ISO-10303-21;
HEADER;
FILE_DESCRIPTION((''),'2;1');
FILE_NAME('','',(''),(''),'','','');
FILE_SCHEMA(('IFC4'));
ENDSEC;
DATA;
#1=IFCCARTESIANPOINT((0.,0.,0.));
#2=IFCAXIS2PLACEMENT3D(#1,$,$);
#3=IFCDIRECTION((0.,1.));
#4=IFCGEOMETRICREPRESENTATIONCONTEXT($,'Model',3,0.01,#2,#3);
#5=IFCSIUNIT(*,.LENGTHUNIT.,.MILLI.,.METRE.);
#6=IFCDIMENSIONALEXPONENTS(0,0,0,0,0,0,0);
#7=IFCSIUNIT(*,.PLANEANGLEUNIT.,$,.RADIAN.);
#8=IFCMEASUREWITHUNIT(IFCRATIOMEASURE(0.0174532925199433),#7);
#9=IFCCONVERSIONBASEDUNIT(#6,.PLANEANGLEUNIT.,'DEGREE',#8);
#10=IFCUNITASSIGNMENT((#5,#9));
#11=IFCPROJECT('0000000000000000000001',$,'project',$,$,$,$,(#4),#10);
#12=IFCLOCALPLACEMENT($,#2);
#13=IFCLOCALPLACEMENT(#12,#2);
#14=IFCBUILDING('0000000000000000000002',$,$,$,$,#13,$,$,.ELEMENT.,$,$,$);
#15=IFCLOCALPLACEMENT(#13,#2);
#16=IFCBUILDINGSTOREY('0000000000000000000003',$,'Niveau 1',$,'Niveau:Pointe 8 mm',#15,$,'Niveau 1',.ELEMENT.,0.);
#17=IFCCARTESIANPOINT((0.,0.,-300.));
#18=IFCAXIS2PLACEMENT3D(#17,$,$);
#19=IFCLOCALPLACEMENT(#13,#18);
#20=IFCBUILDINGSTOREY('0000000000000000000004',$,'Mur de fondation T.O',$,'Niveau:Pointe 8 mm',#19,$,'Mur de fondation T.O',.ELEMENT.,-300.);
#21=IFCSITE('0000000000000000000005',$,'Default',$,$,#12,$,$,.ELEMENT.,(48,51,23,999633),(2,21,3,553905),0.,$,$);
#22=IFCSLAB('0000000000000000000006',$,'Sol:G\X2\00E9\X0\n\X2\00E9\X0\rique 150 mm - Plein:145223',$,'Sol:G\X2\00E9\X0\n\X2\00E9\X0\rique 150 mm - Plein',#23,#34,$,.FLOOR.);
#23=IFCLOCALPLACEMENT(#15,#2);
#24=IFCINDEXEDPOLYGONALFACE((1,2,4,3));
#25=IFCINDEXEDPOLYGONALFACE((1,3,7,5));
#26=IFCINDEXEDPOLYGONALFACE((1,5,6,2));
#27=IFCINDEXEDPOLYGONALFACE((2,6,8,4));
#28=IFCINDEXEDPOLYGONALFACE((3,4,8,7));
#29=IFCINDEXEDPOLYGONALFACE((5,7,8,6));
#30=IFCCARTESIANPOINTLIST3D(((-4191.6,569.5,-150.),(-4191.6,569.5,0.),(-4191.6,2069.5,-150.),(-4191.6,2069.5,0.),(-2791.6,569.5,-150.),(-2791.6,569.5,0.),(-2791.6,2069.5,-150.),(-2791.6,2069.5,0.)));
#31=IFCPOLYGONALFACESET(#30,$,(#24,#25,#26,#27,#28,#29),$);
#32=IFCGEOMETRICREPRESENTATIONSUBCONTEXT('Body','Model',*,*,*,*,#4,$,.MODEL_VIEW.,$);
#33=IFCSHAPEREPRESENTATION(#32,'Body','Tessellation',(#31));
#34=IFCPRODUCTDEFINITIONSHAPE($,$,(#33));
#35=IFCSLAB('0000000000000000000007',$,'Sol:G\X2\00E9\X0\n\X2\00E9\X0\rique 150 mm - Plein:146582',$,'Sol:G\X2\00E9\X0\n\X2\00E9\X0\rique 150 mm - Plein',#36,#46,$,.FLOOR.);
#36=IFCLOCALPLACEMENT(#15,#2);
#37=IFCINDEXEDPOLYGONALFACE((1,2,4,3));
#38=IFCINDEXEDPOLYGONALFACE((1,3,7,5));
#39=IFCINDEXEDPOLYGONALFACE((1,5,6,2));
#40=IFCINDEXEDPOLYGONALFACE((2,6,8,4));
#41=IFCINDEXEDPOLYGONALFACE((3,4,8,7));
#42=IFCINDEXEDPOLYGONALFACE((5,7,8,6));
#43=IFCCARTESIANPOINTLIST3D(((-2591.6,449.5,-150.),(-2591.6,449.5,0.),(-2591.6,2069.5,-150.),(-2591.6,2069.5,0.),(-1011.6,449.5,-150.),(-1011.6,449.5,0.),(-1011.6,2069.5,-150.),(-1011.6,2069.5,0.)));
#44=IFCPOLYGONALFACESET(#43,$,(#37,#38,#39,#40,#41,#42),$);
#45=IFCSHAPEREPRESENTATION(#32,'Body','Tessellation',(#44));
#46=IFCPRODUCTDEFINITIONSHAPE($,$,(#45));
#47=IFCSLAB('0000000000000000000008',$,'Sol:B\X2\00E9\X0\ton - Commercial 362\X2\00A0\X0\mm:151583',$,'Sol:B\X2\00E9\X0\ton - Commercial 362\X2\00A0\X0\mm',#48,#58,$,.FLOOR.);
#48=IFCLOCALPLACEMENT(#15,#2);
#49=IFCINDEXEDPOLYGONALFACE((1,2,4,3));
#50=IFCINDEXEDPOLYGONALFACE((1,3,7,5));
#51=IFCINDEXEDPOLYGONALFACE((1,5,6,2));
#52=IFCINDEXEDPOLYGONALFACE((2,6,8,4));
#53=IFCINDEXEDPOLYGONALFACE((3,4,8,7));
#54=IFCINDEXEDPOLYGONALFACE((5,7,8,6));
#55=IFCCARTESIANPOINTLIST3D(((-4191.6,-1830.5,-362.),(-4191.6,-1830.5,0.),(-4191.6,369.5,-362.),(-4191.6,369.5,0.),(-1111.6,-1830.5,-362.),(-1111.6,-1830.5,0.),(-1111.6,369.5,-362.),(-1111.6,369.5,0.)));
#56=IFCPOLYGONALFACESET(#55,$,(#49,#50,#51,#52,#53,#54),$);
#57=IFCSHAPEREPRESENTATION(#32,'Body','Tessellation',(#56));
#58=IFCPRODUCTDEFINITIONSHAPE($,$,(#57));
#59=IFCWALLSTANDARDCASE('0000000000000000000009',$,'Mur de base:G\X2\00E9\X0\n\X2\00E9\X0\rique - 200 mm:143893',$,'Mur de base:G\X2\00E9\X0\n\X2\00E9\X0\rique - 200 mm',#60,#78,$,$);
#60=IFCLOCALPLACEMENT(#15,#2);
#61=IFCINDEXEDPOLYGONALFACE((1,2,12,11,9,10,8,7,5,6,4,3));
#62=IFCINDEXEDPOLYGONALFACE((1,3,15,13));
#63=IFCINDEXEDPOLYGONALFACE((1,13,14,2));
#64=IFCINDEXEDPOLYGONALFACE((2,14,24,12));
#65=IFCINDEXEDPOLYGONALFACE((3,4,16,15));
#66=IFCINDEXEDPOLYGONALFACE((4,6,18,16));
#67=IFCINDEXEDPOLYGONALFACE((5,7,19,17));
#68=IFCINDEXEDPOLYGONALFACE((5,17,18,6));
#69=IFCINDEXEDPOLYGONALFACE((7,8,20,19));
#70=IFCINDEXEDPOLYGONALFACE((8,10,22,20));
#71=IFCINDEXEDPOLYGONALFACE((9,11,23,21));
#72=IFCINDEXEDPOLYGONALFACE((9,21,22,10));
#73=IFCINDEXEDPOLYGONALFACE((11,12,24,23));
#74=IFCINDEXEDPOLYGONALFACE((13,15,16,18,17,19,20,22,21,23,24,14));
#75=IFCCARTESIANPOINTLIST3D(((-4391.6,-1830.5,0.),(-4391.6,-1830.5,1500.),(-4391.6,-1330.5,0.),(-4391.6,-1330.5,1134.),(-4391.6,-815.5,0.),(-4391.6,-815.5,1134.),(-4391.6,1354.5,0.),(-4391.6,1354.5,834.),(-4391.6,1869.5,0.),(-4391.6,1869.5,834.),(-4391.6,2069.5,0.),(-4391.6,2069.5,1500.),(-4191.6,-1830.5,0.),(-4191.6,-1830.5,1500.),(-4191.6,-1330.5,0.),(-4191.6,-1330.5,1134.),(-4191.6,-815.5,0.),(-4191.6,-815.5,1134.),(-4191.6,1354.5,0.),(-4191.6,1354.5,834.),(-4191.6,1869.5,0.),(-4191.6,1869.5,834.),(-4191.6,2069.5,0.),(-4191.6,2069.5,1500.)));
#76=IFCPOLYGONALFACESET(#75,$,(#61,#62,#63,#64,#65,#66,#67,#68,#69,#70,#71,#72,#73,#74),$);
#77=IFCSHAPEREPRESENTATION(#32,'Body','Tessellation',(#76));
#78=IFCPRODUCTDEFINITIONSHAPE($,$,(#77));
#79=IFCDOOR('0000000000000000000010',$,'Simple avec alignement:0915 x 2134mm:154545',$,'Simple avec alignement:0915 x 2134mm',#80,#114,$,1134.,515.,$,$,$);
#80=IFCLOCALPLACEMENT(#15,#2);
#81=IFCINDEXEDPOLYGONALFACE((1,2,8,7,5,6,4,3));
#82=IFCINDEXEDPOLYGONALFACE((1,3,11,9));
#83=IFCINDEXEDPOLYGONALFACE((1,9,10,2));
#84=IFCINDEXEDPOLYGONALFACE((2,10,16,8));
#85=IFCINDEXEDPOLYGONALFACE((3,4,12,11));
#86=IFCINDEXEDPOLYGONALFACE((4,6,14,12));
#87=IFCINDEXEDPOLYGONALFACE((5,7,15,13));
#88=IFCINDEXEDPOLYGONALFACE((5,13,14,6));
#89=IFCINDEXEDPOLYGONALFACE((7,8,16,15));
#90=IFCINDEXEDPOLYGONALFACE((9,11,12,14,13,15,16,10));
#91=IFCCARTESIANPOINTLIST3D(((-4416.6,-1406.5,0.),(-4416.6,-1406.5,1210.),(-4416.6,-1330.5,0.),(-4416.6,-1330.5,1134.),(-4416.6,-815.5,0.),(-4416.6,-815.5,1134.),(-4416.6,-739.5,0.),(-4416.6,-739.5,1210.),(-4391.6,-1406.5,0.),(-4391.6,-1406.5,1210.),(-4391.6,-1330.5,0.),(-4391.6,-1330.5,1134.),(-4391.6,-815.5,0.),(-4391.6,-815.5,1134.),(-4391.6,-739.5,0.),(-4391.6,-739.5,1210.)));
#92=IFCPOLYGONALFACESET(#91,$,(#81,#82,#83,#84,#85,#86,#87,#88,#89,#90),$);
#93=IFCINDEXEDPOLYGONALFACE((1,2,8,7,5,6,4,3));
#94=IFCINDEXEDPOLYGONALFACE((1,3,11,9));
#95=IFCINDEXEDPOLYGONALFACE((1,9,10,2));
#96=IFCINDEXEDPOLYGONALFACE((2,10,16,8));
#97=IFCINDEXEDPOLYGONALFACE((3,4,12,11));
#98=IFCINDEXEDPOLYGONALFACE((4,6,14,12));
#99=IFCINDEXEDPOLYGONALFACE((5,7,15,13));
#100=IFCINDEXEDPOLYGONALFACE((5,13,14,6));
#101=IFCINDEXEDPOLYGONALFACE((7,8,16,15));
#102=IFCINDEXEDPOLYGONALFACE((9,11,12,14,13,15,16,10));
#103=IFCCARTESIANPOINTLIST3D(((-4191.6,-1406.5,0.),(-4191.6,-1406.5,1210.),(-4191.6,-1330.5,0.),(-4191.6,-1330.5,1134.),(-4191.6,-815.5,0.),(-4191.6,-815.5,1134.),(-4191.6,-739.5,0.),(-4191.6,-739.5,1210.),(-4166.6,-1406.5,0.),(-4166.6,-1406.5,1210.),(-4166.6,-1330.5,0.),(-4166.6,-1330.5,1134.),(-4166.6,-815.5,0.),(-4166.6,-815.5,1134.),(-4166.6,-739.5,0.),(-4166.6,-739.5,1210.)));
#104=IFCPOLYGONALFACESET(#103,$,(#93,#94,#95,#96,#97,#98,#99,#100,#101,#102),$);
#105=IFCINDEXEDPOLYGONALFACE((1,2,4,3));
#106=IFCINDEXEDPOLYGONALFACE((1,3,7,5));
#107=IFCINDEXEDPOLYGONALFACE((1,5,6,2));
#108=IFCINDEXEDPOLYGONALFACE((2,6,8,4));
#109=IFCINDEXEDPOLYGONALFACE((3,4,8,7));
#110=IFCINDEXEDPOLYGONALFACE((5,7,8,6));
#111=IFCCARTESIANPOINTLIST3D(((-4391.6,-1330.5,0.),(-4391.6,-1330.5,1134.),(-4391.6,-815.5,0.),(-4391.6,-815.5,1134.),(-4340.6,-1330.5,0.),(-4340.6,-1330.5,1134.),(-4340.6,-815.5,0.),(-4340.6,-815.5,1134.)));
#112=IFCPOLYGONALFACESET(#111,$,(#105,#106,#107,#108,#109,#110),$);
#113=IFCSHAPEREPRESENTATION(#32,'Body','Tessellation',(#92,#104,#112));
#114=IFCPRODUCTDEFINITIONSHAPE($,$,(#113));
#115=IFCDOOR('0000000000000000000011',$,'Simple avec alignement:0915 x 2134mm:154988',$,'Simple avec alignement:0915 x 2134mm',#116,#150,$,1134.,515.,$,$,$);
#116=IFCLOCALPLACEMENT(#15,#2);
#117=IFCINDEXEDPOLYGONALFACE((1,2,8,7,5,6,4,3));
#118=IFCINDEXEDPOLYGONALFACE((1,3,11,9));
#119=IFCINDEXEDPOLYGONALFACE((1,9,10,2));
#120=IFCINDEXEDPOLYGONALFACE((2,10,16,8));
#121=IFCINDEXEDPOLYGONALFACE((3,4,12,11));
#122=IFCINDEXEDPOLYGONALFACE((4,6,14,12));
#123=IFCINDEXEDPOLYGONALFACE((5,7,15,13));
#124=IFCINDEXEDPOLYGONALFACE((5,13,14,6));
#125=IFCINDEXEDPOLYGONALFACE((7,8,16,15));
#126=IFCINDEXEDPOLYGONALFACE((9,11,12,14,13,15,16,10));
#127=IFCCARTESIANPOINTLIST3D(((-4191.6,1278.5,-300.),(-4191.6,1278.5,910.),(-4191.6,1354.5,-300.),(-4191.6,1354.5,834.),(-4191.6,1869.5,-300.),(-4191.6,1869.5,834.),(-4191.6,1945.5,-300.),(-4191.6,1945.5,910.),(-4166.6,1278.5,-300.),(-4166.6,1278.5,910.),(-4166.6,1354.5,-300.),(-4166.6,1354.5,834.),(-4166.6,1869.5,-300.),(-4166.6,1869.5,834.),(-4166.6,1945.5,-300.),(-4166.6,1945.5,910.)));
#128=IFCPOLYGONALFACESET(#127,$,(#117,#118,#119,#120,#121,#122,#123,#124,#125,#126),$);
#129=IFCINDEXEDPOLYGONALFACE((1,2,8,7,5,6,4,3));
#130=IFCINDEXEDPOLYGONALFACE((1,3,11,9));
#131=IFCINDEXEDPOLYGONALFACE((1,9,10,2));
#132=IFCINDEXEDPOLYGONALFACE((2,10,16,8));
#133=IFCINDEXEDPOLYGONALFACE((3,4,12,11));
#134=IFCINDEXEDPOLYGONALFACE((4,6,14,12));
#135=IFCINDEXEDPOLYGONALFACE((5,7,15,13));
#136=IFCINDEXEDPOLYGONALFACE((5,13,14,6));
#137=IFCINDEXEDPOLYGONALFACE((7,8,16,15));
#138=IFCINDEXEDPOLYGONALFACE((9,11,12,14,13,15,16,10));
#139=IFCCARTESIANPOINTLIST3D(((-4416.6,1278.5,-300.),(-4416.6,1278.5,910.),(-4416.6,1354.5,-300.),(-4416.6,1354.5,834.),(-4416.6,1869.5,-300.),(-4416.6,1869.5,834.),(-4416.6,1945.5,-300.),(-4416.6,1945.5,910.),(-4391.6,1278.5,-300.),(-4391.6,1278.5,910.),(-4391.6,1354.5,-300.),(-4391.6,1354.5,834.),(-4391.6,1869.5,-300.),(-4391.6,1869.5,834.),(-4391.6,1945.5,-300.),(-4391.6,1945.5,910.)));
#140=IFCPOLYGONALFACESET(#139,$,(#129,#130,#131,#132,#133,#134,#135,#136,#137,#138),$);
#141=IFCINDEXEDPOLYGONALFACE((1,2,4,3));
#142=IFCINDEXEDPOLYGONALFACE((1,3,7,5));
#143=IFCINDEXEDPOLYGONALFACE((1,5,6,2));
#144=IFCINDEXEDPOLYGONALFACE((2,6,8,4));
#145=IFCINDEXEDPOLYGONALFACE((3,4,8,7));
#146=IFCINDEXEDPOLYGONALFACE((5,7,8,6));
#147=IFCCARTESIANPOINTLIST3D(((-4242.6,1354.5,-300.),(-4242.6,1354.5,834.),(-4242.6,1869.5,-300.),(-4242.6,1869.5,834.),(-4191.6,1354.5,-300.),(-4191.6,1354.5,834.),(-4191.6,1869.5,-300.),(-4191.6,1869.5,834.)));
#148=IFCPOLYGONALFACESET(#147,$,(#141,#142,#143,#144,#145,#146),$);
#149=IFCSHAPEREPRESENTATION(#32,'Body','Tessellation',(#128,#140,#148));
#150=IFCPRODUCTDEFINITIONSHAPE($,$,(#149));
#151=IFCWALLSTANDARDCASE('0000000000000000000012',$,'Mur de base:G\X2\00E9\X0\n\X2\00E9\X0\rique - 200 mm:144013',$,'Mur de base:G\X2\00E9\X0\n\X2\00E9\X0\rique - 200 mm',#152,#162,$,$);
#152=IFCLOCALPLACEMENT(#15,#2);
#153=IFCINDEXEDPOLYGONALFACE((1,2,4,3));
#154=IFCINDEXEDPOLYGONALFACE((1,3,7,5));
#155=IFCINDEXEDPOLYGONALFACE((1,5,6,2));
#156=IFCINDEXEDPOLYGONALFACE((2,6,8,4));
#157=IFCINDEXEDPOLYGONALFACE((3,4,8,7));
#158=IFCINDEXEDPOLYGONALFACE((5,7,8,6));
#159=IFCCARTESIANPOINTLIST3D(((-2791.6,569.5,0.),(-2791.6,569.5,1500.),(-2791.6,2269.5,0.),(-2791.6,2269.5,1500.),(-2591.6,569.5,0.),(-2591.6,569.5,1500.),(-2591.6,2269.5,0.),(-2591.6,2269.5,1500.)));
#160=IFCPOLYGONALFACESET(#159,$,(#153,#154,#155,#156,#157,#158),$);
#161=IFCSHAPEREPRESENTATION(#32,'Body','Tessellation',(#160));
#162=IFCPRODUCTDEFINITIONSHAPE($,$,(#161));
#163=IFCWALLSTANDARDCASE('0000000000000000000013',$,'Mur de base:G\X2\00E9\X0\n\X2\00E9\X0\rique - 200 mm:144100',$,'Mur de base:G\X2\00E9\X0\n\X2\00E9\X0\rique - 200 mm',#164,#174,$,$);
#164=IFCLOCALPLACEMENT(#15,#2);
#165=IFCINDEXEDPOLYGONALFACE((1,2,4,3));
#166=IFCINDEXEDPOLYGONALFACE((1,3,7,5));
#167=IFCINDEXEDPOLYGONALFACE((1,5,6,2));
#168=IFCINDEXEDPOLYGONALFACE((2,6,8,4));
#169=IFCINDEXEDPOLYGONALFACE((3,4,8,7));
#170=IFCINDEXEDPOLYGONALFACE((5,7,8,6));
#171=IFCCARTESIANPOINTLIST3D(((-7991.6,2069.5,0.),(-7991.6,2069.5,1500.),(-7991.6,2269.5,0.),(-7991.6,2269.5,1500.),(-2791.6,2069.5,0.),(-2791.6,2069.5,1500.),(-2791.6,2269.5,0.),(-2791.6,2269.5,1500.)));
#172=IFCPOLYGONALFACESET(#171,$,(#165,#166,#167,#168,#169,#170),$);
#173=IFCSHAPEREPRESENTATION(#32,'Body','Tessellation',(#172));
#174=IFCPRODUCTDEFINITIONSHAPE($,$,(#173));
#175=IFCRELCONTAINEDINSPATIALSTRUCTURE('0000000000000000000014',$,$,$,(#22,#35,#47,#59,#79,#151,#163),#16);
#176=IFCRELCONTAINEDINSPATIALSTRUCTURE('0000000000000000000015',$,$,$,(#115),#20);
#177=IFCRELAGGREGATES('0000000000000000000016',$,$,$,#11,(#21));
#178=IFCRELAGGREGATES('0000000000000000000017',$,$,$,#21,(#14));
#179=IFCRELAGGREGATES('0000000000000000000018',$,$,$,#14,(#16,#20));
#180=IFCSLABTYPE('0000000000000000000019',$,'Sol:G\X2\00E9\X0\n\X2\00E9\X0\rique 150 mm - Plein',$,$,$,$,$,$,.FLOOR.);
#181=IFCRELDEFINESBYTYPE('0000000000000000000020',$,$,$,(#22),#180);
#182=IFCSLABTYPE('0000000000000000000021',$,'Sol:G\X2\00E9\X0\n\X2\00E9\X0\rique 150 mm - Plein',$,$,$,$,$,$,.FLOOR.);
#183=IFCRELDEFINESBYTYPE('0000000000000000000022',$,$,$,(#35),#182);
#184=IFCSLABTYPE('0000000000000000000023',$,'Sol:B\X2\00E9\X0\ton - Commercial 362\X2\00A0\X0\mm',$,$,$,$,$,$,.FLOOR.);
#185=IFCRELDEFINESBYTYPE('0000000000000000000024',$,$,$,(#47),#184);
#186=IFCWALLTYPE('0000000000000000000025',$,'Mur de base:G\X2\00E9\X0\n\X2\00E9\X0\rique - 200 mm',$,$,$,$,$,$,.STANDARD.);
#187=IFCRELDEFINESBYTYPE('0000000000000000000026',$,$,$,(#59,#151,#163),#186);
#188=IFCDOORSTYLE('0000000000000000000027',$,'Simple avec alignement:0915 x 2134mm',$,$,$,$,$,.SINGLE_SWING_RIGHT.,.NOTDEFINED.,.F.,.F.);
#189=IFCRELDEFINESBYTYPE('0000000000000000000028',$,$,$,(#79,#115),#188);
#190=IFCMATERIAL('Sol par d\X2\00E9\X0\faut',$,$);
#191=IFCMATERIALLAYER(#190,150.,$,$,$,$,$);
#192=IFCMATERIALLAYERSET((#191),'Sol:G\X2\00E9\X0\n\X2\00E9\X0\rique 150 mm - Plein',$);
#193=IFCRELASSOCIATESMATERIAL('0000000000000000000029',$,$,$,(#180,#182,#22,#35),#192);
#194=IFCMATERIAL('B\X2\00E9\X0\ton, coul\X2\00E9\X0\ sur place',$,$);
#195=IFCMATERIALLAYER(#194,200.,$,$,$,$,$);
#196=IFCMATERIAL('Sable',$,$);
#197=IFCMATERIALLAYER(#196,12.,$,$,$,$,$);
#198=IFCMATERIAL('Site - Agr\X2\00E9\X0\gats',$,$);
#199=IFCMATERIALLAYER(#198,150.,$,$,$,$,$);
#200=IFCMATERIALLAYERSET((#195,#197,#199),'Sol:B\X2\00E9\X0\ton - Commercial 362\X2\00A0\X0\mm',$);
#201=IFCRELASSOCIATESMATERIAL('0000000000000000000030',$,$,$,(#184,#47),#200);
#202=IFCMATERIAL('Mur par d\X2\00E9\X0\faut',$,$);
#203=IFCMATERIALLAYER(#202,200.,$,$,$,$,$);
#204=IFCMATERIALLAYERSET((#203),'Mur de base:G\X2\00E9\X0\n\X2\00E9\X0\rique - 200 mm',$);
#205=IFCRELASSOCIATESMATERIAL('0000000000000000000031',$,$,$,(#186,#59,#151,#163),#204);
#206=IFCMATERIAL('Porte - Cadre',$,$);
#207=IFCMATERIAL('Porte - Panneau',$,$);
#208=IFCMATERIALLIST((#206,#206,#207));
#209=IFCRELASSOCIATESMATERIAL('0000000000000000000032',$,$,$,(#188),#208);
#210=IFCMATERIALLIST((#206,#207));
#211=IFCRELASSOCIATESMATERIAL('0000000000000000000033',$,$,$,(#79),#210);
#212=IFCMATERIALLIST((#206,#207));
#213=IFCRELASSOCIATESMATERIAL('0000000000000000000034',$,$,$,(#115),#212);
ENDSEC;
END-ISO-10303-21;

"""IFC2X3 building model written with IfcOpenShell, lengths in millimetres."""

from ifc_helpers import new_model, entity, si_unit, converted_unit, direction, frame, frame_2d, origin, origin_2d_with_axis, place, context, subcontext, project, spatial, polyline, rectangle, outline, extrude, source, transform, mapped, material, material_list, layer, layer_set, layer_usage, type_object, type_shapes, element, fill, save


model = new_model("IFC2X3")

# Units and contexts
model_context = context("Model", 3, precision=0.01, world=origin(), true_north=direction((0.0, 1.0)))
body_context = subcontext(model_context, "Body", "Model", "MODEL_VIEW")
ifc_project = project(units=[si_unit("LENGTHUNIT", "METRE", prefix="MILLI"), converted_unit("PLANEANGLEUNIT", "DEGREE", entity("IfcRatioMeasure", 0.0174532925199433), si_unit("PLANEANGLEUNIT", "RADIAN"), dimensions=[0, 0, 0, 0, 0, 0, 0])], contexts=[model_context])

# Site, building, storey
site_placement = place(None, origin())
site = spatial("IfcSite", under=ifc_project, at=site_placement, Name="Default", CompositionType="ELEMENT", RefLatitude=(48, 51, 23, 999633), RefLongitude=(2, 21, 3, 553905), RefElevation=0.0)
building_placement = place(site_placement, origin())
building = spatial("IfcBuilding", under=site, at=building_placement, CompositionType="ELEMENT")
storey_1_placement = place(building_placement, origin())
storey_1 = spatial("IfcBuildingStorey", under=building, at=storey_1_placement, Name="Niveau 1", ObjectType="Niveau:Pointe 8 mm", LongName="Niveau 1", CompositionType="ELEMENT", Elevation=0.0)

# Slabs
ifc_material_1 = material(Name="Sol par défaut")
ifc_layer_1 = layer(ifc_material_1, 150.0)
ifc_layer_set_1 = layer_set([ifc_layer_1], Name="Sol:Générique 150 mm - Plein")
ifc_layer_usage_1 = layer_usage(ifc_layer_set_1, "AXIS3", "POSITIVE", 0.0)
slab_type_1 = type_object("IfcSlabType", Name="Sol:Générique 150 mm - Plein", PredefinedType="FLOOR", material=ifc_layer_set_1)
slab_1_placement = place(storey_1_placement, origin())
element("IfcSlab", 1, at=slab_1_placement, inside=storey_1, type_object=slab_type_1, material=ifc_layer_usage_1, Name="Sol:Générique 150 mm - Plein:145223", ObjectType="Sol:Générique 150 mm - Plein", PredefinedType="FLOOR", context=body_context, shape_type="SweptSolid", body=[
    extrude(rectangle(XDim=1500.0, YDim=1400.0, at=frame_2d((0.0, 0.0), x_axis=(1.0, 0.0))), frame((-3491.6, 1319.5, 0.0), z_axis=(0.0, 0.0, -1.0), x_axis=(0.0, 1.0, 0.0)), (0.0, 0.0, 1.0), 150.0),
])
ifc_layer_usage_2 = layer_usage(ifc_layer_set_1, "AXIS3", "POSITIVE", 0.0)
slab_type_2 = type_object("IfcSlabType", Name="Sol:Générique 150 mm - Plein", PredefinedType="FLOOR", material=ifc_layer_set_1)
slab_2_placement = place(storey_1_placement, origin())
element("IfcSlab", 2, at=slab_2_placement, inside=storey_1, type_object=slab_type_2, material=ifc_layer_usage_2, Name="Sol:Générique 150 mm - Plein:146582", ObjectType="Sol:Générique 150 mm - Plein", PredefinedType="FLOOR", context=body_context, shape_type="SweptSolid", body=[
    extrude(rectangle(XDim=1620.0, YDim=1580.0, at=origin_2d_with_axis()), frame((-1801.6, 1259.5, 0.0), z_axis=(0.0, 0.0, -1.0), x_axis=(0.0, 1.0, 0.0)), (0.0, 0.0, 1.0), 150.0),
])
ifc_material_2 = material(Name="Béton, coulé sur place")
ifc_layer_2 = layer(ifc_material_2, 200.0)
ifc_material_3 = material(Name="Sable")
ifc_layer_3 = layer(ifc_material_3, 12.0)
ifc_material_4 = material(Name="Site - Agrégats")
ifc_layer_4 = layer(ifc_material_4, 150.0)
ifc_layer_set_2 = layer_set([ifc_layer_2, ifc_layer_3, ifc_layer_4], Name="Sol:Béton - Commercial 362 mm")
ifc_layer_usage_3 = layer_usage(ifc_layer_set_2, "AXIS3", "POSITIVE", 0.0)
slab_type_3 = type_object("IfcSlabType", Name="Sol:Béton - Commercial 362 mm", PredefinedType="FLOOR", material=ifc_layer_set_2)
slab_3_placement = place(storey_1_placement, origin())
element("IfcSlab", 3, at=slab_3_placement, inside=storey_1, type_object=slab_type_3, material=ifc_layer_usage_3, Name="Sol:Béton - Commercial 362 mm:151583", ObjectType="Sol:Béton - Commercial 362 mm", PredefinedType="FLOOR", context=body_context, shape_type="SweptSolid", body=[
    extrude(rectangle(XDim=2200.0, YDim=3080.0, at=frame_2d((0.0, 0.0), x_axis=(1.0, 0.0))), frame((-2651.6, -730.5, 0.0), z_axis=(0.0, 0.0, -1.0), x_axis=(0.0, 1.0, 0.0)), (0.0, 0.0, 1.0), 362.0),
])

# Wall, openings, door
ifc_material_5 = material(Name="Mur par défaut")
ifc_layer_5 = layer(ifc_material_5, 200.0)
ifc_layer_set_3 = layer_set([ifc_layer_5], Name="Mur de base:Générique - 200 mm")
ifc_layer_usage_4 = layer_usage(ifc_layer_set_3, "AXIS2", "NEGATIVE", 100.0)
wall_type = type_object("IfcWallType", Name="Mur de base:Générique - 200 mm", PredefinedType="STANDARD", material=ifc_layer_set_3)
wall_1_placement = place(storey_1_placement, frame((-4291.6, 2069.5, 0.0), z_axis=(0.0, 0.0, 1.0), x_axis=(0.0, -1.0, 0.0)))
wall_1 = element("IfcWallStandardCase", 4, at=wall_1_placement, inside=storey_1, type_object=wall_type, material=ifc_layer_usage_4, Name="Mur de base:Générique - 200 mm:143893", ObjectType="Mur de base:Générique - 200 mm", context=body_context, shape_type="SweptSolid", body=[
    extrude(rectangle(XDim=3900.0, YDim=200.0, at=frame_2d((1950.0, 0.0), x_axis=(-1.0, 0.0))), origin(), (0.0, 0.0, 1.0), 1500.0),
])
opening_1_placement = place(wall_1_placement, frame((3400.0, 100.0, 0.0)))
opening_1 = element("IfcOpeningElement", 5, at=opening_1_placement, cuts=wall_1, ObjectType="Opening", context=body_context, shape_type="SweptSolid", body=[
    extrude(rectangle(XDim=515.0, YDim=1134.0, at=frame_2d((567.0, 257.5), x_axis=(0.0, 1.0))), frame((0.0, 0.0, 0.0), z_axis=(0.0, -1.0, 0.0), x_axis=(0.0, 0.0, 1.0)), (0.0, 0.0, 1.0), 200.0),
])
opening_2_placement = place(wall_1_placement, frame((200.0, -100.0, -300.0)))
opening_2 = element("IfcOpeningElement", 6, at=opening_2_placement, cuts=wall_1, ObjectType="Opening", context=body_context, shape_type="SweptSolid", body=[
    extrude(rectangle(XDim=515.0, YDim=1134.0, at=frame_2d((567.0, 257.5), x_axis=(0.0, 1.0))), frame((0.0, 0.0, 0.0), z_axis=(0.0, 1.0, 0.0), x_axis=(0.0, 0.0, 1.0)), (0.0, 0.0, 1.0), 200.0),
])
ifc_material_6 = material(Name="Porte - Cadre")
ifc_material_7 = material(Name="Porte - Panneau")
ifc_material_list_1 = material_list([ifc_material_6, ifc_material_7])
ifc_material_list_2 = material_list([ifc_material_6, ifc_material_6, ifc_material_7])
door_style = type_object("IfcDoorStyle", Name="Simple avec alignement:0915 x 2134mm", ConstructionType="NOTDEFINED", OperationType="SINGLE_SWING_RIGHT", ParameterTakesPrecedence=False, Sizeable=False, material=ifc_material_list_2)
shared_shape_1 = source(origin(), body_context, "Body", "SweptSolid", [
    extrude(outline(polyline([(-333.5, -624.0), (333.5, -624.0), (333.5, 586.0), (257.5, 586.0), (257.5, -548.0), (-257.5, -548.0), (-257.5, 586.0), (-333.5, 586.0), (-333.5, -624.0)])), frame((257.5, 200.0, 586.0), z_axis=(0.0, 1.0, 0.0), x_axis=(1.0, 0.0, 0.0)), (0.0, 0.0, 1.0), 25.0),
    extrude(outline(polyline([(-624.0, -333.5), (586.0, -333.5), (586.0, -257.5), (-548.0, -257.5), (-548.0, 257.5), (586.0, 257.5), (586.0, 333.5), (-624.0, 333.5), (-624.0, -333.5)])), frame((257.5, -25.0, 586.0), z_axis=(0.0, 1.0, 0.0), x_axis=(0.0, 0.0, -1.0)), (0.0, 0.0, 1.0), 25.0),
    extrude(rectangle(XDim=51.0, YDim=515.0, at=frame_2d((0.0, 0.0), x_axis=(1.0, 0.0))), frame((257.5, 174.5, 0.0), z_axis=(0.0, 0.0, 1.0), x_axis=(0.0, 1.0, 0.0)), (0.0, 0.0, 1.0), 1134.0),
])
type_shapes(door_style, [shared_shape_1])
door_1_placement = place(opening_1_placement, frame((0.0, 0.0, 0.0), z_axis=(0.0, 0.0, 1.0), x_axis=(-1.0, 0.0, 0.0)))
door_1 = element("IfcDoor", 7, at=door_1_placement, inside=storey_1, type_object=door_style, material=ifc_material_list_1, Name="Simple avec alignement:0915 x 2134mm:154545", ObjectType="Simple avec alignement:0915 x 2134mm", OverallHeight=1134.0, OverallWidth=515.0, context=body_context, shape_type="MappedRepresentation", body=[
    mapped(shared_shape_1, transform((0.0, 0.0, 0.0), scale=1.0)),
])
fill(opening_1, door_1)

# Shared definitions
storey_2_placement = place(building_placement, frame((0.0, 0.0, -300.0)))
storey_2 = spatial("IfcBuildingStorey", under=building, at=storey_2_placement, Name="Mur de fondation T.O", ObjectType="Niveau:Pointe 8 mm", LongName="Mur de fondation T.O", CompositionType="ELEMENT", Elevation=-300.0)

# Door
ifc_material_list_3 = material_list([ifc_material_6, ifc_material_7])
door_2_placement = place(opening_2_placement, origin())
door_2 = element("IfcDoor", 8, at=door_2_placement, inside=storey_2, type_object=door_style, material=ifc_material_list_3, Name="Simple avec alignement:0915 x 2134mm:154988", ObjectType="Simple avec alignement:0915 x 2134mm", OverallHeight=1134.0, OverallWidth=515.0, context=body_context, shape_type="MappedRepresentation", body=[
    mapped(shared_shape_1, transform((0.0, 0.0, 0.0), scale=1.0)),
])
fill(opening_2, door_2)

# Walls
ifc_layer_usage_5 = layer_usage(ifc_layer_set_3, "AXIS2", "NEGATIVE", 100.0)
wall_2_placement = place(storey_1_placement, frame((-2691.6, 569.5, 0.0), z_axis=(0.0, 0.0, 1.0), x_axis=(0.0, 1.0, 0.0)))
element("IfcWallStandardCase", 9, at=wall_2_placement, inside=storey_1, type_object=wall_type, material=ifc_layer_usage_5, Name="Mur de base:Générique - 200 mm:144013", ObjectType="Mur de base:Générique - 200 mm", context=body_context, shape_type="SweptSolid", body=[
    extrude(rectangle(XDim=1700.0, YDim=200.0, at=frame_2d((850.0, 0.0), x_axis=(-1.0, 0.0))), origin(), (0.0, 0.0, 1.0), 1500.0),
])
ifc_layer_usage_6 = layer_usage(ifc_layer_set_3, "AXIS2", "NEGATIVE", 100.0)
wall_3_placement = place(storey_1_placement, frame((-2791.6, 2169.5, 0.0), z_axis=(0.0, 0.0, 1.0), x_axis=(-1.0, 0.0, 0.0)))
element("IfcWallStandardCase", 10, at=wall_3_placement, inside=storey_1, type_object=wall_type, material=ifc_layer_usage_6, Name="Mur de base:Générique - 200 mm:144100", ObjectType="Mur de base:Générique - 200 mm", context=body_context, shape_type="SweptSolid", body=[
    extrude(rectangle(XDim=5200.0, YDim=200.0, at=frame_2d((2600.0, 0.0), x_axis=(-1.0, 0.0))), origin(), (0.0, 0.0, 1.0), 1500.0),
])

save(model, "model.ifc")
